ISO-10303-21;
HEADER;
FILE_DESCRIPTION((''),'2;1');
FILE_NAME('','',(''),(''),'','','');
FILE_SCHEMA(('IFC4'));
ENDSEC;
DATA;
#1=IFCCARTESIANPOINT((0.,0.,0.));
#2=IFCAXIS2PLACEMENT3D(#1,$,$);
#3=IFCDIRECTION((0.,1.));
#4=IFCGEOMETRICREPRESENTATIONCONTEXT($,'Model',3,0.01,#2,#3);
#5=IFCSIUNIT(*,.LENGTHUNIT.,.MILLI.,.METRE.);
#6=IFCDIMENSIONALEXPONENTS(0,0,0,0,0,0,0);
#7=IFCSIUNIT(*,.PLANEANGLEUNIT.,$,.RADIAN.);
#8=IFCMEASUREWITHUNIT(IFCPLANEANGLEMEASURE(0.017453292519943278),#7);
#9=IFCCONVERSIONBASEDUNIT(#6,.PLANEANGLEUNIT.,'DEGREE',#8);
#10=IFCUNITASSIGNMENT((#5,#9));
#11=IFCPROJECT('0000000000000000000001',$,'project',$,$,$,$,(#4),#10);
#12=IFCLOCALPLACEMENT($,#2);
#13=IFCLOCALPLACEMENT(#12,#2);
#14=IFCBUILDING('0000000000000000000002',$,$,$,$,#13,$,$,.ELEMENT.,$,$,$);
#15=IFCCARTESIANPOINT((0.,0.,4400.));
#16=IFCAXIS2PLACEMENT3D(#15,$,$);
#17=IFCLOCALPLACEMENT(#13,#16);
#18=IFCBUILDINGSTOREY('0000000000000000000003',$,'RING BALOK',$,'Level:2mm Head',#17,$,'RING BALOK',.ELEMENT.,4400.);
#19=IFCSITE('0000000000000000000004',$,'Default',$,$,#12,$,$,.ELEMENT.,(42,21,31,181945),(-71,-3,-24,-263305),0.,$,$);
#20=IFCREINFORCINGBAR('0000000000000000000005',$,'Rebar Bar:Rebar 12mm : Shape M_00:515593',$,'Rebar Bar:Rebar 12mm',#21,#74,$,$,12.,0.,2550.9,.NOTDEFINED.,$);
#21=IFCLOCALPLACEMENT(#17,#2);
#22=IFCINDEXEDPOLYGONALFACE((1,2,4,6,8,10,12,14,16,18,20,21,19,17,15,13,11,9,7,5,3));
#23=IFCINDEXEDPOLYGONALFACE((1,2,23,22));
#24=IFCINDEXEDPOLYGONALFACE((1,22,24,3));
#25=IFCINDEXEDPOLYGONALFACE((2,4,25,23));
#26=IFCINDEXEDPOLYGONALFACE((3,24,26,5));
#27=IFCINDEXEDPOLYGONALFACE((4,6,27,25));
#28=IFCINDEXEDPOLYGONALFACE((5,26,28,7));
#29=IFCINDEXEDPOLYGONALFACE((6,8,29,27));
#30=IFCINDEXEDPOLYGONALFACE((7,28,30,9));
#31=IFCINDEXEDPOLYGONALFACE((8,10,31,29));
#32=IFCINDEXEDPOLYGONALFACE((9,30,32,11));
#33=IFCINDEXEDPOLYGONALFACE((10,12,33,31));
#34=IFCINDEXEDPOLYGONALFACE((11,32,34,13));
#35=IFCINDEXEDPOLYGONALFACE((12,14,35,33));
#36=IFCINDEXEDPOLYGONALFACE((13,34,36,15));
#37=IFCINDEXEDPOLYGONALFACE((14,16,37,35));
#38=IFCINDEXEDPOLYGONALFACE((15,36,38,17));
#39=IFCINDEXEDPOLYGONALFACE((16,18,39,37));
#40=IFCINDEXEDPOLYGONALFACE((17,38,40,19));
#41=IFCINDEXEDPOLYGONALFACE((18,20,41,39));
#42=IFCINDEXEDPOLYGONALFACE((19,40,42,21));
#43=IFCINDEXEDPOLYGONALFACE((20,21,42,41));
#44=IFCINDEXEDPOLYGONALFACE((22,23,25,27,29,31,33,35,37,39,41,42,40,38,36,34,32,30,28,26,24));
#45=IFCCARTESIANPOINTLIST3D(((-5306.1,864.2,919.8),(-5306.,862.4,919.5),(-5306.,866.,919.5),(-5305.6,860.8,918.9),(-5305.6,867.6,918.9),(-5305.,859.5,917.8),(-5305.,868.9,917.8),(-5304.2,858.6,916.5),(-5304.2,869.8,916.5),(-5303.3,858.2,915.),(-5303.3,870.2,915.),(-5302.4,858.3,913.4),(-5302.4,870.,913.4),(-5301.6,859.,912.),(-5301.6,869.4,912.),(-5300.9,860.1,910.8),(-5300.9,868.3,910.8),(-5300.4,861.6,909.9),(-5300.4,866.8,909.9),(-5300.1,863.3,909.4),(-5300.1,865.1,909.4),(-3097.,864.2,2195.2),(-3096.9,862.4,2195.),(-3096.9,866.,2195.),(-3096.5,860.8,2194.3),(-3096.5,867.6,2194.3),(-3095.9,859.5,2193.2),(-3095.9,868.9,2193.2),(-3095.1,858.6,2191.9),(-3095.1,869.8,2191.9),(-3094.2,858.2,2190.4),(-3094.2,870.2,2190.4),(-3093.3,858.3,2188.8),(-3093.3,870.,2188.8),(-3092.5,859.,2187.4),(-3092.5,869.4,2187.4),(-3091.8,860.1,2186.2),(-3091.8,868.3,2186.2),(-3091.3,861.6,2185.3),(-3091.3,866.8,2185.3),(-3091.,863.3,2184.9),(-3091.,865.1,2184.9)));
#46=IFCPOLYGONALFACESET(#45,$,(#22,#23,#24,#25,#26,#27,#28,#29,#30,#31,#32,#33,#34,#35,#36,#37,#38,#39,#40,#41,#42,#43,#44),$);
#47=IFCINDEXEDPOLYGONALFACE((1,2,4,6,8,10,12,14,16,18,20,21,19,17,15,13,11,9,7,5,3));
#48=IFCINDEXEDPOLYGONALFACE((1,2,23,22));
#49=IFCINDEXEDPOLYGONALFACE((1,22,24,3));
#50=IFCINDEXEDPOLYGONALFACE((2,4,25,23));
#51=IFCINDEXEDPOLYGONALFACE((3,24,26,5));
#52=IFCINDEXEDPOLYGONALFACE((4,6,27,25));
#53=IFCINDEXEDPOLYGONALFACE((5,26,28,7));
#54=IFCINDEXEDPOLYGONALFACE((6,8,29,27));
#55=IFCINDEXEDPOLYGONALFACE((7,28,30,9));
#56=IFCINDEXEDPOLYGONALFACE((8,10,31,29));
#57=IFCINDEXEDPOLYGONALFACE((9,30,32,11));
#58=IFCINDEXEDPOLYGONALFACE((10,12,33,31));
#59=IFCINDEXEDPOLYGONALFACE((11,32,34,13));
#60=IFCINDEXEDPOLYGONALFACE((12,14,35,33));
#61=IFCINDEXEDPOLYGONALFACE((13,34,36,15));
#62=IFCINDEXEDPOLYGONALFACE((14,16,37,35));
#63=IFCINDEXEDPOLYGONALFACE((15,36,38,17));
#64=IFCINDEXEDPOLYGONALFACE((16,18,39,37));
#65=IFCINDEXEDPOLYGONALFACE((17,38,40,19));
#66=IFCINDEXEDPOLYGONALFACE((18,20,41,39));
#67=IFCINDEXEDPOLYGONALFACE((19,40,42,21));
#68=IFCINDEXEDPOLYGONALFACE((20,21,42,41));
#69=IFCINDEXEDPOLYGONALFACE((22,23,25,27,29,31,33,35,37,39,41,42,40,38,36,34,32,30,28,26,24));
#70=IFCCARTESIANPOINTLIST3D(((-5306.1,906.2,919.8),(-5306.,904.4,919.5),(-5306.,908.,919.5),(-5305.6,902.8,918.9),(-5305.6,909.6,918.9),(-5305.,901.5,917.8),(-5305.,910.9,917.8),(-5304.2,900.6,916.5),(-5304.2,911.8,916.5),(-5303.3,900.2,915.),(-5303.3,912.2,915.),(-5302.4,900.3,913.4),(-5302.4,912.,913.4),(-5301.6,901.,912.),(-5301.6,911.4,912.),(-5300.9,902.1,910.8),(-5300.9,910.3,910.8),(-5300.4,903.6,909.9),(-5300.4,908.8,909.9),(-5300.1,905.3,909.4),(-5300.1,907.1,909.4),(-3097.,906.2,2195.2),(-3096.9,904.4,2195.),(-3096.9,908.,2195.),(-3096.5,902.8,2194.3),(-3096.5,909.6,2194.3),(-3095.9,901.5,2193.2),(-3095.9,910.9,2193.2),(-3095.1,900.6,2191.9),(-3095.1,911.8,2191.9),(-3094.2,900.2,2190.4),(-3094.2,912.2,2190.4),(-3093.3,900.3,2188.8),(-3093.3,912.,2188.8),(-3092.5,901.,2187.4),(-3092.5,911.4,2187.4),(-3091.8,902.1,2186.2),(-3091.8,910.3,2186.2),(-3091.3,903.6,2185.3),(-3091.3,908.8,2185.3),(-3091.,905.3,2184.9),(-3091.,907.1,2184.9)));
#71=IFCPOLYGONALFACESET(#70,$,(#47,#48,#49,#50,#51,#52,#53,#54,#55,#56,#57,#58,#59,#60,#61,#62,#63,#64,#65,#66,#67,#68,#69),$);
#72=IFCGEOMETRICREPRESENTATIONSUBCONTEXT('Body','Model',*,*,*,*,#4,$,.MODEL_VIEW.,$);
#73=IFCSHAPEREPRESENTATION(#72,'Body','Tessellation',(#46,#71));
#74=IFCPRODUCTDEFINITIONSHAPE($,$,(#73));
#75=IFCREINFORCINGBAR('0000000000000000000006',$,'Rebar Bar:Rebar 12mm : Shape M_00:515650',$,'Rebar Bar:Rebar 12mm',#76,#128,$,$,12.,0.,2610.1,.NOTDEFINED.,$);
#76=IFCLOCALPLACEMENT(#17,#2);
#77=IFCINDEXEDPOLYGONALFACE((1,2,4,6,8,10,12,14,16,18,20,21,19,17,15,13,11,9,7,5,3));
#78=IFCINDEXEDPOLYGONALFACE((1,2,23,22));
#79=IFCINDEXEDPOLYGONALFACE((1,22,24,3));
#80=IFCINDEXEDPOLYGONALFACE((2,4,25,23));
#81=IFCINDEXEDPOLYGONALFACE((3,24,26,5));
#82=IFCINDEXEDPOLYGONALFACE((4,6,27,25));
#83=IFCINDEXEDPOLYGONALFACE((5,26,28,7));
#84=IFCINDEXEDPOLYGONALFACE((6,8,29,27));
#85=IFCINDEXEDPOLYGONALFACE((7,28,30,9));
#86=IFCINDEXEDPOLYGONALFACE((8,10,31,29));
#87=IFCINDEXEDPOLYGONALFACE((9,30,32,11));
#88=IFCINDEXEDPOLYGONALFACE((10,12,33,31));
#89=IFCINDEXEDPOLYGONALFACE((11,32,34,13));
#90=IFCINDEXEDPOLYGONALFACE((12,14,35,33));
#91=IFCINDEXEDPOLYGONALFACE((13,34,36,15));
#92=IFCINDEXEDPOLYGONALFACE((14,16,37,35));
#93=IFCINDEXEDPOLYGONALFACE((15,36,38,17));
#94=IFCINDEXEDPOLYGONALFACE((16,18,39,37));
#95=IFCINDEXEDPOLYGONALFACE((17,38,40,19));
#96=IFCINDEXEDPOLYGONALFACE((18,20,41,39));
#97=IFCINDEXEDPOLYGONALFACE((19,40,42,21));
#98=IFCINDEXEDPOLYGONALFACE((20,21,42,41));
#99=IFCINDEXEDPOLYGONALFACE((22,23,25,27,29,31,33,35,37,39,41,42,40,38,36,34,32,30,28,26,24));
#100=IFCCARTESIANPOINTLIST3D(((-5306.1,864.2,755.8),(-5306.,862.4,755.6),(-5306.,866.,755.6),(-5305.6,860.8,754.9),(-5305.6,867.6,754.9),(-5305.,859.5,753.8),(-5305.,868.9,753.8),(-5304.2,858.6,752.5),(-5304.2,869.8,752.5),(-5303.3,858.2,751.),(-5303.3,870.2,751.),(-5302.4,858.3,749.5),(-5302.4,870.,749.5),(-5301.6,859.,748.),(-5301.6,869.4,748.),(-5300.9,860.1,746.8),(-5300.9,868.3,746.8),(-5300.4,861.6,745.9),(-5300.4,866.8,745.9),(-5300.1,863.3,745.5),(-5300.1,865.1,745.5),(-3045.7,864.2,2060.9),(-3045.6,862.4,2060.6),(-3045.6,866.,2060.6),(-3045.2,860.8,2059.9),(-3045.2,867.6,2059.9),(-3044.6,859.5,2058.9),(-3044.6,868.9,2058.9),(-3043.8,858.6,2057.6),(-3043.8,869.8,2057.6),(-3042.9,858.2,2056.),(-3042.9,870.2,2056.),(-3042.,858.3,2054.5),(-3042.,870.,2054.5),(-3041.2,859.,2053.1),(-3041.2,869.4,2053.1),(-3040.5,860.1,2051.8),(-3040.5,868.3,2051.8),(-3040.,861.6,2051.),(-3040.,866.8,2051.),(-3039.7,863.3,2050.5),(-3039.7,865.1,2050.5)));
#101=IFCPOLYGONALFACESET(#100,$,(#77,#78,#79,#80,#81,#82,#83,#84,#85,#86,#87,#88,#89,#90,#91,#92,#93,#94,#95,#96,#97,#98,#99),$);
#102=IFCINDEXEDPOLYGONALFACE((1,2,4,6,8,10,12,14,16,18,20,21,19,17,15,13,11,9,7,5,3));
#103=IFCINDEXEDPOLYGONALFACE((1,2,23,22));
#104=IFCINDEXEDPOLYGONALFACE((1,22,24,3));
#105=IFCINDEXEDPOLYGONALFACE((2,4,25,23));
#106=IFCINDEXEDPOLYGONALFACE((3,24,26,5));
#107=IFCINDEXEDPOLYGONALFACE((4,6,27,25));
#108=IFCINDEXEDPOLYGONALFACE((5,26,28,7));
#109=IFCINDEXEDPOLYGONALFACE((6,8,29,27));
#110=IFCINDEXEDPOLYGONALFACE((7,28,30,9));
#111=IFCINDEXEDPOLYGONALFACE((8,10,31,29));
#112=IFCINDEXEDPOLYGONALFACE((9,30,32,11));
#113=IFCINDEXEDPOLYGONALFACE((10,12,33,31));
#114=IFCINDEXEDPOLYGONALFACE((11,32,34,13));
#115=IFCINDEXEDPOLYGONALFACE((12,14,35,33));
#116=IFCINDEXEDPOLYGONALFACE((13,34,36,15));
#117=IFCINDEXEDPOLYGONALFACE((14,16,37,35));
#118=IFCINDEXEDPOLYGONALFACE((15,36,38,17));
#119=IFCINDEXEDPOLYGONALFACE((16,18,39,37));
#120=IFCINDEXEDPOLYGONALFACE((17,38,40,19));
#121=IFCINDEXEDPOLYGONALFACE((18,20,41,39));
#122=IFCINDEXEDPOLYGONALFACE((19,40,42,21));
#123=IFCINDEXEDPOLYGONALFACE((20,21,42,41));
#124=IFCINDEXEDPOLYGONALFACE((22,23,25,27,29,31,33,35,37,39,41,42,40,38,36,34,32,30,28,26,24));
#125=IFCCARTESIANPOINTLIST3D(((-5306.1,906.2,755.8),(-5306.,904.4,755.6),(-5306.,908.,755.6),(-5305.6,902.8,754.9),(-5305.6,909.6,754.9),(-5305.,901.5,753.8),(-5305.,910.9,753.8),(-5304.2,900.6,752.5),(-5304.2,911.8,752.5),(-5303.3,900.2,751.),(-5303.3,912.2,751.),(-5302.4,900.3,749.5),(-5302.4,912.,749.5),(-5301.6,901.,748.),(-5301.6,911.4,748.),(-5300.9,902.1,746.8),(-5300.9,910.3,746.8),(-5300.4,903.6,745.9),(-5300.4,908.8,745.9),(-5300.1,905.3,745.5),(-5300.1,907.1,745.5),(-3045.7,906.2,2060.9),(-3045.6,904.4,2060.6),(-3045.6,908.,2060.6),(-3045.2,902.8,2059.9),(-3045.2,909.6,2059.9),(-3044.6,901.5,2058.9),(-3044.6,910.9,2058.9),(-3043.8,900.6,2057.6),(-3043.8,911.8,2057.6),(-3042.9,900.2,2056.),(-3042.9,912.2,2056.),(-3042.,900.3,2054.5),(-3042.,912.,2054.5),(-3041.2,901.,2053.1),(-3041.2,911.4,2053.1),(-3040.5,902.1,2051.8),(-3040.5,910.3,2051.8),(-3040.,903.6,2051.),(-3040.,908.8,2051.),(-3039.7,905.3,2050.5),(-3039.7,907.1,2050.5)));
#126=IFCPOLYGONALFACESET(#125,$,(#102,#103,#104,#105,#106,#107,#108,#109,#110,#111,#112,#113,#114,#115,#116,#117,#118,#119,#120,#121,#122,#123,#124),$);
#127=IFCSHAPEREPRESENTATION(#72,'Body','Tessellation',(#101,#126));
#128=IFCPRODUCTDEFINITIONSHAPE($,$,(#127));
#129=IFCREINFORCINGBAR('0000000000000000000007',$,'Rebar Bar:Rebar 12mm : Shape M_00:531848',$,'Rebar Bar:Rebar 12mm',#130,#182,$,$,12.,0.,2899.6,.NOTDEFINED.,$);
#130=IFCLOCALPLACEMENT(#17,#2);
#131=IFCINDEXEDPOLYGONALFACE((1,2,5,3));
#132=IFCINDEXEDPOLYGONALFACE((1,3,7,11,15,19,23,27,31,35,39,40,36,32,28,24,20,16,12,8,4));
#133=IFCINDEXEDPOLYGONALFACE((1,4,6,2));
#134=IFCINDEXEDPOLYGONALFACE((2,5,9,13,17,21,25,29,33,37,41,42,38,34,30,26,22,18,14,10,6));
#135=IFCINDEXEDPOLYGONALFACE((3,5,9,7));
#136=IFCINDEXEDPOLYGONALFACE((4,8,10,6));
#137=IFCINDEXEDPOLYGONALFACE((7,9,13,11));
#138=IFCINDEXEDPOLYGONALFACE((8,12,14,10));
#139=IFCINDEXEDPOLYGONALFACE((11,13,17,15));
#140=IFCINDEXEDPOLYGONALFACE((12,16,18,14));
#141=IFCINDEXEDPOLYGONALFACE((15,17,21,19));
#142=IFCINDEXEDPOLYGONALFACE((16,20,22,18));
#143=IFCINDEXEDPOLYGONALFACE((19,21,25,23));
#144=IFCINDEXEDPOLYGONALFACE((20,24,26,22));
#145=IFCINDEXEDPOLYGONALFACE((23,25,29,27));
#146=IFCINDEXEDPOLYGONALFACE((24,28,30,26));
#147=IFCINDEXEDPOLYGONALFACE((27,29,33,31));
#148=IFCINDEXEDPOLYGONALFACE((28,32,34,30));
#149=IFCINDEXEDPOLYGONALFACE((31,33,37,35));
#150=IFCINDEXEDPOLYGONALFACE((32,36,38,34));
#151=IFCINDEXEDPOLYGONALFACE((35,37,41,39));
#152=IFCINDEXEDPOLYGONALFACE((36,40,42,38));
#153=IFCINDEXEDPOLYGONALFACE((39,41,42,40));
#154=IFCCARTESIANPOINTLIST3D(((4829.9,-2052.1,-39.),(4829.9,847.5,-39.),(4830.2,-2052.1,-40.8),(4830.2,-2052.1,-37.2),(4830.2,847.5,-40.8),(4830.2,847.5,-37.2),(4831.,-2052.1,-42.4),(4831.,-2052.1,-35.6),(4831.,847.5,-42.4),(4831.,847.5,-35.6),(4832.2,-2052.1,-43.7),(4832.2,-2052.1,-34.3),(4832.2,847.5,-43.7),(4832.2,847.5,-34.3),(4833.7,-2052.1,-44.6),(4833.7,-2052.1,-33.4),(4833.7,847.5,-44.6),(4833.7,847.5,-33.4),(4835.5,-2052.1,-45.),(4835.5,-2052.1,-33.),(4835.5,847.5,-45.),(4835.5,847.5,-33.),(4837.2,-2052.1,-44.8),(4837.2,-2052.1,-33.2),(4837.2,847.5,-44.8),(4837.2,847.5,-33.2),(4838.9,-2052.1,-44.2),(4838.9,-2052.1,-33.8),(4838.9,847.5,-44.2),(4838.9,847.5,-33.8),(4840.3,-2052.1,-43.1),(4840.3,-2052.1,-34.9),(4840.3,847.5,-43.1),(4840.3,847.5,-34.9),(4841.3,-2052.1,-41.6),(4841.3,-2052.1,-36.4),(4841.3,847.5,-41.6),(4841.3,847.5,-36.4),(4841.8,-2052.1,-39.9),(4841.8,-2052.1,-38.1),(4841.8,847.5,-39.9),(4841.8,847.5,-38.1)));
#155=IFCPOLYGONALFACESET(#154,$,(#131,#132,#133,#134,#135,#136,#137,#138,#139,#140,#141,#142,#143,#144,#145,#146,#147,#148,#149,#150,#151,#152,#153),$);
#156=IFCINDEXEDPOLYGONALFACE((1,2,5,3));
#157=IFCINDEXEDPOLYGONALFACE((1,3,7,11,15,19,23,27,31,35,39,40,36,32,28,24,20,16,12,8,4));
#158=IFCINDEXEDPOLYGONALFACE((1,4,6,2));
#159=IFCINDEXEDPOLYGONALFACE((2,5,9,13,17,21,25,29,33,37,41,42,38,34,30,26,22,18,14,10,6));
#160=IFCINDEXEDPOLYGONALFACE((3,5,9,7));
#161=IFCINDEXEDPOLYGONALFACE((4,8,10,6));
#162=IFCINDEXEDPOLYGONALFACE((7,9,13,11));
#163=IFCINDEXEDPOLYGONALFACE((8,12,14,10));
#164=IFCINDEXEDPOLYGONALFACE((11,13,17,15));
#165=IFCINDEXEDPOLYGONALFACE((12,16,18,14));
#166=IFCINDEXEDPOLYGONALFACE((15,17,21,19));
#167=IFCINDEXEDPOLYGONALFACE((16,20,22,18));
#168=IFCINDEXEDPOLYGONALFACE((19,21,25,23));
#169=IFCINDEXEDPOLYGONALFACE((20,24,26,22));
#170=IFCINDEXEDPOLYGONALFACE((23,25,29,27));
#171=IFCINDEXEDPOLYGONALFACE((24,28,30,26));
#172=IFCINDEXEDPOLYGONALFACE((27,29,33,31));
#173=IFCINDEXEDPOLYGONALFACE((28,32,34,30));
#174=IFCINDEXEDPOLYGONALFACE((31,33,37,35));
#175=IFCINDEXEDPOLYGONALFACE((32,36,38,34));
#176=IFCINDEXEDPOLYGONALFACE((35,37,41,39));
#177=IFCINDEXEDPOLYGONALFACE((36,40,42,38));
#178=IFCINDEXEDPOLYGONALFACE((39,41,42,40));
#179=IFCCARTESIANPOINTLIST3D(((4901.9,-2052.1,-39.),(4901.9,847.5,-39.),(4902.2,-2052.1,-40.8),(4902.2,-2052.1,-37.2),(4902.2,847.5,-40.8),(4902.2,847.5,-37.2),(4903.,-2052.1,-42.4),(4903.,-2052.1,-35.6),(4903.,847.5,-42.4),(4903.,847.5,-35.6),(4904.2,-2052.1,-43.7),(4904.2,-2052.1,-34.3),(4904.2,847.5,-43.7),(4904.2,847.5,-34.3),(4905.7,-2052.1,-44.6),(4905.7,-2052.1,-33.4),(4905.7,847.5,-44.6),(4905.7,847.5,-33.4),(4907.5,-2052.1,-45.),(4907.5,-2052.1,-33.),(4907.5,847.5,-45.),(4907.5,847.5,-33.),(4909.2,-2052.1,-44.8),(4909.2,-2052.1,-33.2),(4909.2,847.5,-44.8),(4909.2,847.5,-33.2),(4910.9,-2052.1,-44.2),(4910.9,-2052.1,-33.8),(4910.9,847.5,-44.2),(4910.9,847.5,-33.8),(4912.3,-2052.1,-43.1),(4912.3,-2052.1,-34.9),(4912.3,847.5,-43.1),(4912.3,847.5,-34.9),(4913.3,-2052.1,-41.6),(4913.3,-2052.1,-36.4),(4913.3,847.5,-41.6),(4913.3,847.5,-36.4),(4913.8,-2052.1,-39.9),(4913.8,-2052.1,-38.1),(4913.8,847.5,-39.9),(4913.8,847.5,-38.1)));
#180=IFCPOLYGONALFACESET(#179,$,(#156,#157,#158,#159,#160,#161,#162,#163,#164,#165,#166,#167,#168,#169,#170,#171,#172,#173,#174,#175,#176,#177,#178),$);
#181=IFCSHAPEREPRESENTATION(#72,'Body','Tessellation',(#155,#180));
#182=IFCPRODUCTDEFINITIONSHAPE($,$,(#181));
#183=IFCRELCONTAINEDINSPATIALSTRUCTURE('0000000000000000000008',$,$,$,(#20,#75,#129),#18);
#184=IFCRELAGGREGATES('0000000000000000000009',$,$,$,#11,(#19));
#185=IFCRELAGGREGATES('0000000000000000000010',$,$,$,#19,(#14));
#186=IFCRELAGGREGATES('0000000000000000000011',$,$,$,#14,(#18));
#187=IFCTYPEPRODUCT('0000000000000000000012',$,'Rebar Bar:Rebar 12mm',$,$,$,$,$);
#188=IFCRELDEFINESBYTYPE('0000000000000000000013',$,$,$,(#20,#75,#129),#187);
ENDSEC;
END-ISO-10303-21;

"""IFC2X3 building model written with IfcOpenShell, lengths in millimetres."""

from ifc_helpers import new_model, entity, si_unit, converted_unit, direction, frame, origin, place, context, subcontext, project, spatial, type_object, element, save


model = new_model("IFC2X3")

# Units and contexts
model_context = context("Model", 3, precision=0.01, world=origin(), true_north=direction((0.0, 1.0)))
body_context = subcontext(model_context, "Body", "Model", "MODEL_VIEW")
ifc_project = project(units=[si_unit("LENGTHUNIT", "METRE", prefix="MILLI"), converted_unit("PLANEANGLEUNIT", "DEGREE", entity("IfcPlaneAngleMeasure", 0.017453292519943278), si_unit("PLANEANGLEUNIT", "RADIAN"), dimensions=[0, 0, 0, 0, 0, 0, 0])], contexts=[model_context])

# Site, building, storey
site_placement = place(None, origin())
site = spatial("IfcSite", under=ifc_project, at=site_placement, Name="Default", CompositionType="ELEMENT", RefLatitude=(42, 21, 31, 181945), RefLongitude=(-71, -3, -24, -263305), RefElevation=0.0)
building_placement = place(site_placement, origin())
building = spatial("IfcBuilding", under=site, at=building_placement, CompositionType="ELEMENT")
storey_placement = place(building_placement, frame((0.0, 0.0, 4400.0)))
storey = spatial("IfcBuildingStorey", under=building, at=storey_placement, Name="RING BALOK", ObjectType="Level:2mm Head", LongName="RING BALOK", CompositionType="ELEMENT", Elevation=4400.0)

# Reinforcing bars
type_product_1 = type_object("IfcTypeProduct", Name="Rebar Bar:Rebar 12mm")
reinforcing_bar_1_placement = place(storey_placement, origin())
element("IfcReinforcingBar", 1, at=reinforcing_bar_1_placement, inside=storey, type_object=type_product_1, Name="Rebar Bar:Rebar 12mm : Shape M_00:515593", ObjectType="Rebar Bar:Rebar 12mm", BarLength=2550.9, BarRole="NOTDEFINED", CrossSectionArea=0.0, NominalDiameter=12.0, context=body_context, shape_type="AdvancedSweptSolid", body=[
    entity("IfcSweptDiskSolid", entity("IfcCompositeCurve", [entity("IfcCompositeCurveSegment", "CONTINUOUS", True, entity("IfcPolyline", [entity("IfcCartesianPoint", [-5303.1, 864.2, 914.6]), entity("IfcCartesianPoint", [-3094.0, 864.2, 2190.0])]))], False), 6.0, None, 0.0, 1.0),
    entity("IfcSweptDiskSolid", entity("IfcCompositeCurve", [entity("IfcCompositeCurveSegment", "CONTINUOUS", True, entity("IfcPolyline", [entity("IfcCartesianPoint", [-5303.1, 906.2, 914.6]), entity("IfcCartesianPoint", [-3094.0, 906.2, 2190.0])]))], False), 6.0, None, 0.0, 1.0),
])
reinforcing_bar_2_placement = place(storey_placement, origin())
element("IfcReinforcingBar", 2, at=reinforcing_bar_2_placement, inside=storey, type_object=type_product_1, Name="Rebar Bar:Rebar 12mm : Shape M_00:515650", ObjectType="Rebar Bar:Rebar 12mm", BarLength=2610.1, BarRole="NOTDEFINED", CrossSectionArea=0.0, NominalDiameter=12.0, context=body_context, shape_type="AdvancedSweptSolid", body=[
    entity("IfcSweptDiskSolid", entity("IfcCompositeCurve", [entity("IfcCompositeCurveSegment", "CONTINUOUS", True, entity("IfcPolyline", [entity("IfcCartesianPoint", [-5303.1, 864.2, 750.6]), entity("IfcCartesianPoint", [-3042.7, 864.2, 2055.7])]))], False), 6.0, None, 0.0, 1.0),
    entity("IfcSweptDiskSolid", entity("IfcCompositeCurve", [entity("IfcCompositeCurveSegment", "CONTINUOUS", True, entity("IfcPolyline", [entity("IfcCartesianPoint", [-5303.1, 906.2, 750.6]), entity("IfcCartesianPoint", [-3042.7, 906.2, 2055.7])]))], False), 6.0, None, 0.0, 1.0),
])
reinforcing_bar_3_placement = place(storey_placement, origin())
element("IfcReinforcingBar", 3, at=reinforcing_bar_3_placement, inside=storey, type_object=type_product_1, Name="Rebar Bar:Rebar 12mm : Shape M_00:531848", ObjectType="Rebar Bar:Rebar 12mm", BarLength=2899.6, BarRole="NOTDEFINED", CrossSectionArea=0.0, NominalDiameter=12.0, context=body_context, shape_type="AdvancedSweptSolid", body=[
    entity("IfcSweptDiskSolid", entity("IfcCompositeCurve", [entity("IfcCompositeCurveSegment", "CONTINUOUS", True, entity("IfcPolyline", [entity("IfcCartesianPoint", [4835.9, 847.5, -39.0]), entity("IfcCartesianPoint", [4835.9, -2052.1, -39.0])]))], False), 6.0, None, 0.0, 1.0),
    entity("IfcSweptDiskSolid", entity("IfcCompositeCurve", [entity("IfcCompositeCurveSegment", "CONTINUOUS", True, entity("IfcPolyline", [entity("IfcCartesianPoint", [4907.9, 847.5, -39.0]), entity("IfcCartesianPoint", [4907.9, -2052.1, -39.0])]))], False), 6.0, None, 0.0, 1.0),
])

save(model, "model.ifc")
